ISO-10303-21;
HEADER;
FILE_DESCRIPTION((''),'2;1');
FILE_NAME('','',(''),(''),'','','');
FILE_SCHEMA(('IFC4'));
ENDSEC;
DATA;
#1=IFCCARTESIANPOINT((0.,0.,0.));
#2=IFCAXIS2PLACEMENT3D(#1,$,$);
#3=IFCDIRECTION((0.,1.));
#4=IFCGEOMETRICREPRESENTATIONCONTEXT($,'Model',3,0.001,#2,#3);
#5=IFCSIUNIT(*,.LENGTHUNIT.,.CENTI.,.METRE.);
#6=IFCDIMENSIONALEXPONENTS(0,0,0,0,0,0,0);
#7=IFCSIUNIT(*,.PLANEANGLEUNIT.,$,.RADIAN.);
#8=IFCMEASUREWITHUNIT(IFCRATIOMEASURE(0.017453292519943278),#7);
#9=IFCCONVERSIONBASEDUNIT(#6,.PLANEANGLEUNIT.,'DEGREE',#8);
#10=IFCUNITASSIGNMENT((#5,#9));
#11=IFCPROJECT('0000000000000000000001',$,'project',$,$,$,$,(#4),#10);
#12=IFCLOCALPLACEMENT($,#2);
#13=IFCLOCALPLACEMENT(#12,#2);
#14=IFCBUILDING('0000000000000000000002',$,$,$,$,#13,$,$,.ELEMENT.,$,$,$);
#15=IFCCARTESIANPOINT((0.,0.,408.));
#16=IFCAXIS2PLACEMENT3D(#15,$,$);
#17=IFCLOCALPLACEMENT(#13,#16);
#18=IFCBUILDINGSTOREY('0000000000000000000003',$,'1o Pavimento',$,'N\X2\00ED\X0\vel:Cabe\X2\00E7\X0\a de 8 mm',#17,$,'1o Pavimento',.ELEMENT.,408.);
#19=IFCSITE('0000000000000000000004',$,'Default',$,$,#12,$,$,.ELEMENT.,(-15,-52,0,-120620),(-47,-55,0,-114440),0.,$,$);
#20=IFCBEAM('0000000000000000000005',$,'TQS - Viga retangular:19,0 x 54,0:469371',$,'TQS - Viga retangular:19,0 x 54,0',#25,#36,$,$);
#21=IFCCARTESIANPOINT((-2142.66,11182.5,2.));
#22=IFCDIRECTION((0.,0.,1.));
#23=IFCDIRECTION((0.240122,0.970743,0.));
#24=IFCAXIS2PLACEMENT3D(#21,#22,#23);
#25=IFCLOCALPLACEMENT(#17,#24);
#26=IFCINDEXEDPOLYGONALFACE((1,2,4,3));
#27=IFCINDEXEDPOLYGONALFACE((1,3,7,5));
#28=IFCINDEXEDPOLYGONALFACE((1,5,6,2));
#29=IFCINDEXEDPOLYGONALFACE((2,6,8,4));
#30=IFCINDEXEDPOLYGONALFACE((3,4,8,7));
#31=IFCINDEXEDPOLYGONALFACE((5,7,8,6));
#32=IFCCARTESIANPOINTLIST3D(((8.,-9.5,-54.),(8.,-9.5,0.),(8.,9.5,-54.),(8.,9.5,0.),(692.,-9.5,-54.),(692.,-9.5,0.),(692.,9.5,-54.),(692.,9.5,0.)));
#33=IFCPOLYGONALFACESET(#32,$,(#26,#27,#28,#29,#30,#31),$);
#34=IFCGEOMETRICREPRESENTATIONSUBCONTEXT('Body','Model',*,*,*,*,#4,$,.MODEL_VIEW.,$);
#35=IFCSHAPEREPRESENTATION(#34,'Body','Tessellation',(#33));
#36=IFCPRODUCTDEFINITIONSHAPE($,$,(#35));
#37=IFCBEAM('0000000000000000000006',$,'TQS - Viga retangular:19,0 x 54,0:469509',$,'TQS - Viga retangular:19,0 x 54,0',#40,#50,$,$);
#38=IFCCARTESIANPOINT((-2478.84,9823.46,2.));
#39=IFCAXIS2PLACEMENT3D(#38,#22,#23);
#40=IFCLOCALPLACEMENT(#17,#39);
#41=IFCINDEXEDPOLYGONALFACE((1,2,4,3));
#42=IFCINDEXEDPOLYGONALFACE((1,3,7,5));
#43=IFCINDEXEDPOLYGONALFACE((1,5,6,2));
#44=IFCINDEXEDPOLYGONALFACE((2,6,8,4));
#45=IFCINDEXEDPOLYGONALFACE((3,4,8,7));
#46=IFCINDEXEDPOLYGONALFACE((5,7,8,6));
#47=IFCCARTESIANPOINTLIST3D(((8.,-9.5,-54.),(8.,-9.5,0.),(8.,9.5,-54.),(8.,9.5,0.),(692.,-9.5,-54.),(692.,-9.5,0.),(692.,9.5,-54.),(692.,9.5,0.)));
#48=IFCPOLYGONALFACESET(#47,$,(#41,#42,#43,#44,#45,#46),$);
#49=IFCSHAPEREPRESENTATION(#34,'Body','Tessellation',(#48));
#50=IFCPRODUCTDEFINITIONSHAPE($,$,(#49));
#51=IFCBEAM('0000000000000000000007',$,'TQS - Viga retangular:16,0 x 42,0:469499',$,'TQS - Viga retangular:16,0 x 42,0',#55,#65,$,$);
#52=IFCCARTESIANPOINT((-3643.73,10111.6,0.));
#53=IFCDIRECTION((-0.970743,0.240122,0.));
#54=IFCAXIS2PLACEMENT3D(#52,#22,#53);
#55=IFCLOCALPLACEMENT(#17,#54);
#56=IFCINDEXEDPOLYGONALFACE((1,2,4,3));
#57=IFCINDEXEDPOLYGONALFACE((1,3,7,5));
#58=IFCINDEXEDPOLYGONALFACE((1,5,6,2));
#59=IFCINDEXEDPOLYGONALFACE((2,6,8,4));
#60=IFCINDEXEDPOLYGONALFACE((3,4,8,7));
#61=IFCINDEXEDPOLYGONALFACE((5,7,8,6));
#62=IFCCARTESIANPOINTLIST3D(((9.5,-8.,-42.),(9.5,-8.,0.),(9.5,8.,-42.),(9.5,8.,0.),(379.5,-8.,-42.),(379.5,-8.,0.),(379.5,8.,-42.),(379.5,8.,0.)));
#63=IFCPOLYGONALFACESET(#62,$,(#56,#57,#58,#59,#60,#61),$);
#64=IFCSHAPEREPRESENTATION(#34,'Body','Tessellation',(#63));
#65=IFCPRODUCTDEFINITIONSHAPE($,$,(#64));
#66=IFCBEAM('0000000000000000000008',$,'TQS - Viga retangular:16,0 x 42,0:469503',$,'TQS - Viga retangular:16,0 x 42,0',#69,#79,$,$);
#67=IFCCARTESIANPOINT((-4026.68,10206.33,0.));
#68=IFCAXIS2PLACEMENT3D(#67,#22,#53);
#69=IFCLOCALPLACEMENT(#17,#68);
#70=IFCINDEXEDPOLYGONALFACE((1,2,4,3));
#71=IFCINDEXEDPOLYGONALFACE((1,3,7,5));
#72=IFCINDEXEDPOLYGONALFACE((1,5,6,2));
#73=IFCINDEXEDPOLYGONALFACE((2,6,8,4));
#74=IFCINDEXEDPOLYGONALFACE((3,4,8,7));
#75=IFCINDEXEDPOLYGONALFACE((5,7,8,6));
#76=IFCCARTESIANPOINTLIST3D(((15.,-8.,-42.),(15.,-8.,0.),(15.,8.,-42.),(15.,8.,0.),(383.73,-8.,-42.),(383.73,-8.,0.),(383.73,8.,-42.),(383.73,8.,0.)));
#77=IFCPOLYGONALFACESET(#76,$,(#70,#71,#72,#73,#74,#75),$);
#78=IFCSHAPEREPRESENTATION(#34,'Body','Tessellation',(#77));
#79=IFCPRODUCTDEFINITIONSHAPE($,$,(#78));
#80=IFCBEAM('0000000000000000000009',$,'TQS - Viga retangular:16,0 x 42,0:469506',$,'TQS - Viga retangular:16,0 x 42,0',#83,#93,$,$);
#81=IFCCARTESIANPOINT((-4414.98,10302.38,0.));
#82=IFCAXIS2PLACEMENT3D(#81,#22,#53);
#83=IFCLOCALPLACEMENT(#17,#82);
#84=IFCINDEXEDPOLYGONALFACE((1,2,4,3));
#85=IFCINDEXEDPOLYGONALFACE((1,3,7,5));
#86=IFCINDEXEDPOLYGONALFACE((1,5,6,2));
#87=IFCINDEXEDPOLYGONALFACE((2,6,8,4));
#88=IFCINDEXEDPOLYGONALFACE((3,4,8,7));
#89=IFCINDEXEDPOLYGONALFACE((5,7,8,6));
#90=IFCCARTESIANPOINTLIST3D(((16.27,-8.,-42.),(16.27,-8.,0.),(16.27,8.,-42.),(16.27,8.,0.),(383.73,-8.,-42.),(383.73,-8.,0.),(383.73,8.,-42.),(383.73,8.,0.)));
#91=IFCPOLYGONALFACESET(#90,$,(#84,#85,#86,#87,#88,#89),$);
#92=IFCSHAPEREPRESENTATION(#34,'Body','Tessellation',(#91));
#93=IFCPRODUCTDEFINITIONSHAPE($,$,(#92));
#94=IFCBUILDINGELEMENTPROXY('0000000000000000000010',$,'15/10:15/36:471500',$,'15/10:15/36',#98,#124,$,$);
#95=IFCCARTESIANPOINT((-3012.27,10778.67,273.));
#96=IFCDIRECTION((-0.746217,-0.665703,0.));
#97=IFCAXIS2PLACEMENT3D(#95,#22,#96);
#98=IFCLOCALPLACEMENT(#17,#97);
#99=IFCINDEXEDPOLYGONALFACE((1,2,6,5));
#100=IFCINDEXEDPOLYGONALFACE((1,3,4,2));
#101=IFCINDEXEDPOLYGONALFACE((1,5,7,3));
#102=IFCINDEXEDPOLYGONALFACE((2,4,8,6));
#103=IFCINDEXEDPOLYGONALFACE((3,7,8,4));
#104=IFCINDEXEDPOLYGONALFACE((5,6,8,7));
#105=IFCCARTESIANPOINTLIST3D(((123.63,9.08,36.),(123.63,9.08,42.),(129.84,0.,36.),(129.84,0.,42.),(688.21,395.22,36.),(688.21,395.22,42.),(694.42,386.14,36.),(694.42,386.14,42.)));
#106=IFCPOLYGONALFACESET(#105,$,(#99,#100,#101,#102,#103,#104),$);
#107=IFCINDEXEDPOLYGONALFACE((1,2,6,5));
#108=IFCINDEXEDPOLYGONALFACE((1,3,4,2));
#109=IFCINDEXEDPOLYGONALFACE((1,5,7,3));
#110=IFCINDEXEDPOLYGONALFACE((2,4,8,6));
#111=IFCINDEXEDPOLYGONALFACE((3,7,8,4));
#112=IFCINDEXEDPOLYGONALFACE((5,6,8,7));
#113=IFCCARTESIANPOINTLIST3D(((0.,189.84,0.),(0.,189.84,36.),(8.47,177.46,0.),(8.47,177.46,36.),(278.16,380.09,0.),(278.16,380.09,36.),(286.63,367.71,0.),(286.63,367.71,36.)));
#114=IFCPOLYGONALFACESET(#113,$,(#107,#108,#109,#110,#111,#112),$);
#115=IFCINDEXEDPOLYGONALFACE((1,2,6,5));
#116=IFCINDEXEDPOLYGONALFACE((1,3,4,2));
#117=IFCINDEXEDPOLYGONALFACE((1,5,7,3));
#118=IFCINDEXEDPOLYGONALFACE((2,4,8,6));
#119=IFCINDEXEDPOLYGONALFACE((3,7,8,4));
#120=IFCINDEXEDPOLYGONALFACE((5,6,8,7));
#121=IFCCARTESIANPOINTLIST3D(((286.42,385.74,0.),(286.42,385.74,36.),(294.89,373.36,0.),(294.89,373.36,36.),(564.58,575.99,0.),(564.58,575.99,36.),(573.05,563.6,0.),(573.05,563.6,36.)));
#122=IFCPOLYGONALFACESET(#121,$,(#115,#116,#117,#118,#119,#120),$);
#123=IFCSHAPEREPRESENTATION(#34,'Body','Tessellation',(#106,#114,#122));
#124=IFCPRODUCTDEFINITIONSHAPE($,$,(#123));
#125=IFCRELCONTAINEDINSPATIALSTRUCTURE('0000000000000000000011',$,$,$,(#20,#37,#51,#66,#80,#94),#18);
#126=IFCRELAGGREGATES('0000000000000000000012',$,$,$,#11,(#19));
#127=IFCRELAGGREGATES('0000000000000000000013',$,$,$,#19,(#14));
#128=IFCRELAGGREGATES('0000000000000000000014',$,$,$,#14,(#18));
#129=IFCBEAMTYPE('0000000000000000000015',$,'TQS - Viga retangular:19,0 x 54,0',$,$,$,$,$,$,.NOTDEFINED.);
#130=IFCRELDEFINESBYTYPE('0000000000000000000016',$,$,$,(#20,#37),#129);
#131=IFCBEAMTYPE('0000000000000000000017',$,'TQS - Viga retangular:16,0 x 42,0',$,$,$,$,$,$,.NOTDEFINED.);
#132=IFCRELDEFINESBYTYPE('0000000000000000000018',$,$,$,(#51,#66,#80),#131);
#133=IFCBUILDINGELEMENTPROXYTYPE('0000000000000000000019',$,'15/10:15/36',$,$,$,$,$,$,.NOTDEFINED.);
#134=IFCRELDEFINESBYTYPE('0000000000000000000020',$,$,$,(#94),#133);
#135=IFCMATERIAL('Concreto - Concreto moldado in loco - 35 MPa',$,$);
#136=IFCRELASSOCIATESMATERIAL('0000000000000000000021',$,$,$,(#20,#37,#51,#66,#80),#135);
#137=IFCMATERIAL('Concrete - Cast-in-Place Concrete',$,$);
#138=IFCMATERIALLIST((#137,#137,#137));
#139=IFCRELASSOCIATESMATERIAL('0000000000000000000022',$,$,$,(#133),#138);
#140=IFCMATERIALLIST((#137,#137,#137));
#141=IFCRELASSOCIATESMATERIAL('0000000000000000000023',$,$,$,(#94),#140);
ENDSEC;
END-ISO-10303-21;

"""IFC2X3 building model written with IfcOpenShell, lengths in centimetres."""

from ifc_helpers import new_model, entity, si_unit, converted_unit, direction, frame, frame_2d, origin, origin_2d_with_axis, place, context, subcontext, project, spatial, rectangle, extrude, source, transform, mapped, material, material_list, type_object, type_shapes, element, save


model = new_model("IFC2X3")

# Units and contexts
model_context = context("Model", 3, precision=0.001, world=origin(), true_north=direction((0.0, 1.0)))
body_context = subcontext(model_context, "Body", "Model", "MODEL_VIEW")
ifc_project = project(units=[si_unit("LENGTHUNIT", "METRE", prefix="CENTI"), converted_unit("PLANEANGLEUNIT", "DEGREE", entity("IfcRatioMeasure", 0.017453292519943278), si_unit("PLANEANGLEUNIT", "RADIAN"), dimensions=[0, 0, 0, 0, 0, 0, 0])], contexts=[model_context])

# Site, building, storey
site_placement = place(None, origin())
site = spatial("IfcSite", under=ifc_project, at=site_placement, Name="Default", CompositionType="ELEMENT", RefLatitude=(-15, -52, 0, -120620), RefLongitude=(-47, -55, 0, -114440), RefElevation=0.0)
building_placement = place(site_placement, origin())
building = spatial("IfcBuilding", under=site, at=building_placement, CompositionType="ELEMENT")
storey_placement = place(building_placement, frame((0.0, 0.0, 408.0)))
storey = spatial("IfcBuildingStorey", under=building, at=storey_placement, Name="1o Pavimento", ObjectType="Nível:Cabeça de 8 mm", LongName="1o Pavimento", CompositionType="ELEMENT", Elevation=408.0)

# Beams
ifc_material_1 = material(Name="Concreto - Concreto moldado in loco - 35 MPa")
beam_type_1 = type_object("IfcBeamType", Name="TQS - Viga retangular:19,0 x 54,0", PredefinedType="NOTDEFINED")
beam_1_placement = place(storey_placement, frame((-2142.66, 11182.5, 2.0), z_axis=(0.0, 0.0, 1.0), x_axis=(0.240122, 0.970743, 0.0)))
element("IfcBeam", 1, at=beam_1_placement, inside=storey, type_object=beam_type_1, material=ifc_material_1, Name="TQS - Viga retangular:19,0 x 54,0:469371", ObjectType="TQS - Viga retangular:19,0 x 54,0", context=body_context, shape_type="SweptSolid", body=[
    extrude(rectangle(XDim=54.0, YDim=19.0, at=origin_2d_with_axis()), frame((8.0, 0.0, -27.0), z_axis=(1.0, 0.0, 0.0), x_axis=(0.0, 0.0, -1.0)), (0.0, 0.0, 1.0), 684.0),
])
beam_2_placement = place(storey_placement, frame((-2478.84, 9823.46, 2.0), z_axis=(0.0, 0.0, 1.0), x_axis=(0.240122, 0.970743, 0.0)))
element("IfcBeam", 2, at=beam_2_placement, inside=storey, type_object=beam_type_1, material=ifc_material_1, Name="TQS - Viga retangular:19,0 x 54,0:469509", ObjectType="TQS - Viga retangular:19,0 x 54,0", context=body_context, shape_type="SweptSolid", body=[
    extrude(rectangle(XDim=54.0, YDim=19.0, at=frame_2d((0.0, 0.0), x_axis=(1.0, 0.0))), frame((8.0, 0.0, -27.0), z_axis=(1.0, 0.0, 0.0), x_axis=(0.0, 0.0, -1.0)), (0.0, 0.0, 1.0), 684.0),
])
beam_type_2 = type_object("IfcBeamType", Name="TQS - Viga retangular:16,0 x 42,0", PredefinedType="NOTDEFINED")
beam_3_placement = place(storey_placement, frame((-3643.73, 10111.6, 0.0), z_axis=(0.0, 0.0, 1.0), x_axis=(-0.970743, 0.240122, 0.0)))
element("IfcBeam", 3, at=beam_3_placement, inside=storey, type_object=beam_type_2, material=ifc_material_1, Name="TQS - Viga retangular:16,0 x 42,0:469499", ObjectType="TQS - Viga retangular:16,0 x 42,0", context=body_context, shape_type="SweptSolid", body=[
    extrude(rectangle(XDim=42.0, YDim=16.0, at=frame_2d((0.0, 0.0), x_axis=(1.0, 0.0))), frame((9.5, 0.0, -21.0), z_axis=(1.0, 0.0, 0.0), x_axis=(0.0, 0.0, -1.0)), (0.0, 0.0, 1.0), 370.0),
])
beam_4_placement = place(storey_placement, frame((-4026.68, 10206.33, 0.0), z_axis=(0.0, 0.0, 1.0), x_axis=(-0.970743, 0.240122, 0.0)))
element("IfcBeam", 4, at=beam_4_placement, inside=storey, type_object=beam_type_2, material=ifc_material_1, Name="TQS - Viga retangular:16,0 x 42,0:469503", ObjectType="TQS - Viga retangular:16,0 x 42,0", context=body_context, shape_type="SweptSolid", body=[
    extrude(rectangle(XDim=42.0, YDim=16.0, at=origin_2d_with_axis()), frame((15.0, 0.0, -21.0), z_axis=(1.0, 0.0, 0.0), x_axis=(0.0, 0.0, -1.0)), (0.0, 0.0, 1.0), 368.73),
])
beam_5_placement = place(storey_placement, frame((-4414.98, 10302.38, 0.0), z_axis=(0.0, 0.0, 1.0), x_axis=(-0.970743, 0.240122, 0.0)))
element("IfcBeam", 5, at=beam_5_placement, inside=storey, type_object=beam_type_2, material=ifc_material_1, Name="TQS - Viga retangular:16,0 x 42,0:469506", ObjectType="TQS - Viga retangular:16,0 x 42,0", context=body_context, shape_type="SweptSolid", body=[
    extrude(rectangle(XDim=42.0, YDim=16.0, at=frame_2d((0.0, 0.0), x_axis=(1.0, 0.0))), frame((16.27, 0.0, -21.0), z_axis=(1.0, 0.0, 0.0), x_axis=(0.0, 0.0, -1.0)), (0.0, 0.0, 1.0), 367.46),
])

# Building element proxy
ifc_material_2 = material(Name="Concrete - Cast-in-Place Concrete")
ifc_material_list_1 = material_list([ifc_material_2, ifc_material_2, ifc_material_2])
ifc_material_list_2 = material_list([ifc_material_2, ifc_material_2, ifc_material_2])
building_element_proxy_type_1 = type_object("IfcBuildingElementProxyType", Name="15/10:15/36", PredefinedType="NOTDEFINED", material=ifc_material_list_2)
shared_shape_1 = source(origin(), body_context, "Body", "SweptSolid", [
    extrude(rectangle(XDim=11.0, YDim=684.0, at=frame_2d((0.0, 0.0), x_axis=(1.0, 0.0))), frame((409.03, 197.61, 36.0), z_axis=(0.0, 0.0, 1.0), x_axis=(-0.564535, 0.825409, 0.0)), (0.0, 0.0, 1.0), 6.0),
    extrude(rectangle(XDim=337.0, YDim=15.0, at=frame_2d((0.0, 0.0), x_axis=(1.0, 0.0))), frame((143.32, 278.78, 0.0), z_axis=(0.0, 0.0, 1.0), x_axis=(0.825409, 0.564535, 0.0)), (0.0, 0.0, 1.0), 36.0),
    extrude(rectangle(XDim=337.0, YDim=15.0, at=frame_2d((0.0, 0.0), x_axis=(1.0, 0.0))), frame((429.73, 474.67, 0.0), z_axis=(0.0, 0.0, 1.0), x_axis=(0.825409, 0.564535, 0.0)), (0.0, 0.0, 1.0), 36.0),
])
type_shapes(building_element_proxy_type_1, [shared_shape_1])
proxy_1_placement = place(storey_placement, frame((-3012.27, 10778.67, 273.0), z_axis=(0.0, 0.0, 1.0), x_axis=(-0.746217, -0.665703, 0.0)))
element("IfcBuildingElementProxy", 6, at=proxy_1_placement, inside=storey, type_object=building_element_proxy_type_1, material=ifc_material_list_1, Name="15/10:15/36:471500", ObjectType="15/10:15/36", context=body_context, shape_type="MappedRepresentation", body=[
    mapped(shared_shape_1, transform((0.0, 0.0, 0.0), scale=1.0)),
])

save(model, "model.ifc")
